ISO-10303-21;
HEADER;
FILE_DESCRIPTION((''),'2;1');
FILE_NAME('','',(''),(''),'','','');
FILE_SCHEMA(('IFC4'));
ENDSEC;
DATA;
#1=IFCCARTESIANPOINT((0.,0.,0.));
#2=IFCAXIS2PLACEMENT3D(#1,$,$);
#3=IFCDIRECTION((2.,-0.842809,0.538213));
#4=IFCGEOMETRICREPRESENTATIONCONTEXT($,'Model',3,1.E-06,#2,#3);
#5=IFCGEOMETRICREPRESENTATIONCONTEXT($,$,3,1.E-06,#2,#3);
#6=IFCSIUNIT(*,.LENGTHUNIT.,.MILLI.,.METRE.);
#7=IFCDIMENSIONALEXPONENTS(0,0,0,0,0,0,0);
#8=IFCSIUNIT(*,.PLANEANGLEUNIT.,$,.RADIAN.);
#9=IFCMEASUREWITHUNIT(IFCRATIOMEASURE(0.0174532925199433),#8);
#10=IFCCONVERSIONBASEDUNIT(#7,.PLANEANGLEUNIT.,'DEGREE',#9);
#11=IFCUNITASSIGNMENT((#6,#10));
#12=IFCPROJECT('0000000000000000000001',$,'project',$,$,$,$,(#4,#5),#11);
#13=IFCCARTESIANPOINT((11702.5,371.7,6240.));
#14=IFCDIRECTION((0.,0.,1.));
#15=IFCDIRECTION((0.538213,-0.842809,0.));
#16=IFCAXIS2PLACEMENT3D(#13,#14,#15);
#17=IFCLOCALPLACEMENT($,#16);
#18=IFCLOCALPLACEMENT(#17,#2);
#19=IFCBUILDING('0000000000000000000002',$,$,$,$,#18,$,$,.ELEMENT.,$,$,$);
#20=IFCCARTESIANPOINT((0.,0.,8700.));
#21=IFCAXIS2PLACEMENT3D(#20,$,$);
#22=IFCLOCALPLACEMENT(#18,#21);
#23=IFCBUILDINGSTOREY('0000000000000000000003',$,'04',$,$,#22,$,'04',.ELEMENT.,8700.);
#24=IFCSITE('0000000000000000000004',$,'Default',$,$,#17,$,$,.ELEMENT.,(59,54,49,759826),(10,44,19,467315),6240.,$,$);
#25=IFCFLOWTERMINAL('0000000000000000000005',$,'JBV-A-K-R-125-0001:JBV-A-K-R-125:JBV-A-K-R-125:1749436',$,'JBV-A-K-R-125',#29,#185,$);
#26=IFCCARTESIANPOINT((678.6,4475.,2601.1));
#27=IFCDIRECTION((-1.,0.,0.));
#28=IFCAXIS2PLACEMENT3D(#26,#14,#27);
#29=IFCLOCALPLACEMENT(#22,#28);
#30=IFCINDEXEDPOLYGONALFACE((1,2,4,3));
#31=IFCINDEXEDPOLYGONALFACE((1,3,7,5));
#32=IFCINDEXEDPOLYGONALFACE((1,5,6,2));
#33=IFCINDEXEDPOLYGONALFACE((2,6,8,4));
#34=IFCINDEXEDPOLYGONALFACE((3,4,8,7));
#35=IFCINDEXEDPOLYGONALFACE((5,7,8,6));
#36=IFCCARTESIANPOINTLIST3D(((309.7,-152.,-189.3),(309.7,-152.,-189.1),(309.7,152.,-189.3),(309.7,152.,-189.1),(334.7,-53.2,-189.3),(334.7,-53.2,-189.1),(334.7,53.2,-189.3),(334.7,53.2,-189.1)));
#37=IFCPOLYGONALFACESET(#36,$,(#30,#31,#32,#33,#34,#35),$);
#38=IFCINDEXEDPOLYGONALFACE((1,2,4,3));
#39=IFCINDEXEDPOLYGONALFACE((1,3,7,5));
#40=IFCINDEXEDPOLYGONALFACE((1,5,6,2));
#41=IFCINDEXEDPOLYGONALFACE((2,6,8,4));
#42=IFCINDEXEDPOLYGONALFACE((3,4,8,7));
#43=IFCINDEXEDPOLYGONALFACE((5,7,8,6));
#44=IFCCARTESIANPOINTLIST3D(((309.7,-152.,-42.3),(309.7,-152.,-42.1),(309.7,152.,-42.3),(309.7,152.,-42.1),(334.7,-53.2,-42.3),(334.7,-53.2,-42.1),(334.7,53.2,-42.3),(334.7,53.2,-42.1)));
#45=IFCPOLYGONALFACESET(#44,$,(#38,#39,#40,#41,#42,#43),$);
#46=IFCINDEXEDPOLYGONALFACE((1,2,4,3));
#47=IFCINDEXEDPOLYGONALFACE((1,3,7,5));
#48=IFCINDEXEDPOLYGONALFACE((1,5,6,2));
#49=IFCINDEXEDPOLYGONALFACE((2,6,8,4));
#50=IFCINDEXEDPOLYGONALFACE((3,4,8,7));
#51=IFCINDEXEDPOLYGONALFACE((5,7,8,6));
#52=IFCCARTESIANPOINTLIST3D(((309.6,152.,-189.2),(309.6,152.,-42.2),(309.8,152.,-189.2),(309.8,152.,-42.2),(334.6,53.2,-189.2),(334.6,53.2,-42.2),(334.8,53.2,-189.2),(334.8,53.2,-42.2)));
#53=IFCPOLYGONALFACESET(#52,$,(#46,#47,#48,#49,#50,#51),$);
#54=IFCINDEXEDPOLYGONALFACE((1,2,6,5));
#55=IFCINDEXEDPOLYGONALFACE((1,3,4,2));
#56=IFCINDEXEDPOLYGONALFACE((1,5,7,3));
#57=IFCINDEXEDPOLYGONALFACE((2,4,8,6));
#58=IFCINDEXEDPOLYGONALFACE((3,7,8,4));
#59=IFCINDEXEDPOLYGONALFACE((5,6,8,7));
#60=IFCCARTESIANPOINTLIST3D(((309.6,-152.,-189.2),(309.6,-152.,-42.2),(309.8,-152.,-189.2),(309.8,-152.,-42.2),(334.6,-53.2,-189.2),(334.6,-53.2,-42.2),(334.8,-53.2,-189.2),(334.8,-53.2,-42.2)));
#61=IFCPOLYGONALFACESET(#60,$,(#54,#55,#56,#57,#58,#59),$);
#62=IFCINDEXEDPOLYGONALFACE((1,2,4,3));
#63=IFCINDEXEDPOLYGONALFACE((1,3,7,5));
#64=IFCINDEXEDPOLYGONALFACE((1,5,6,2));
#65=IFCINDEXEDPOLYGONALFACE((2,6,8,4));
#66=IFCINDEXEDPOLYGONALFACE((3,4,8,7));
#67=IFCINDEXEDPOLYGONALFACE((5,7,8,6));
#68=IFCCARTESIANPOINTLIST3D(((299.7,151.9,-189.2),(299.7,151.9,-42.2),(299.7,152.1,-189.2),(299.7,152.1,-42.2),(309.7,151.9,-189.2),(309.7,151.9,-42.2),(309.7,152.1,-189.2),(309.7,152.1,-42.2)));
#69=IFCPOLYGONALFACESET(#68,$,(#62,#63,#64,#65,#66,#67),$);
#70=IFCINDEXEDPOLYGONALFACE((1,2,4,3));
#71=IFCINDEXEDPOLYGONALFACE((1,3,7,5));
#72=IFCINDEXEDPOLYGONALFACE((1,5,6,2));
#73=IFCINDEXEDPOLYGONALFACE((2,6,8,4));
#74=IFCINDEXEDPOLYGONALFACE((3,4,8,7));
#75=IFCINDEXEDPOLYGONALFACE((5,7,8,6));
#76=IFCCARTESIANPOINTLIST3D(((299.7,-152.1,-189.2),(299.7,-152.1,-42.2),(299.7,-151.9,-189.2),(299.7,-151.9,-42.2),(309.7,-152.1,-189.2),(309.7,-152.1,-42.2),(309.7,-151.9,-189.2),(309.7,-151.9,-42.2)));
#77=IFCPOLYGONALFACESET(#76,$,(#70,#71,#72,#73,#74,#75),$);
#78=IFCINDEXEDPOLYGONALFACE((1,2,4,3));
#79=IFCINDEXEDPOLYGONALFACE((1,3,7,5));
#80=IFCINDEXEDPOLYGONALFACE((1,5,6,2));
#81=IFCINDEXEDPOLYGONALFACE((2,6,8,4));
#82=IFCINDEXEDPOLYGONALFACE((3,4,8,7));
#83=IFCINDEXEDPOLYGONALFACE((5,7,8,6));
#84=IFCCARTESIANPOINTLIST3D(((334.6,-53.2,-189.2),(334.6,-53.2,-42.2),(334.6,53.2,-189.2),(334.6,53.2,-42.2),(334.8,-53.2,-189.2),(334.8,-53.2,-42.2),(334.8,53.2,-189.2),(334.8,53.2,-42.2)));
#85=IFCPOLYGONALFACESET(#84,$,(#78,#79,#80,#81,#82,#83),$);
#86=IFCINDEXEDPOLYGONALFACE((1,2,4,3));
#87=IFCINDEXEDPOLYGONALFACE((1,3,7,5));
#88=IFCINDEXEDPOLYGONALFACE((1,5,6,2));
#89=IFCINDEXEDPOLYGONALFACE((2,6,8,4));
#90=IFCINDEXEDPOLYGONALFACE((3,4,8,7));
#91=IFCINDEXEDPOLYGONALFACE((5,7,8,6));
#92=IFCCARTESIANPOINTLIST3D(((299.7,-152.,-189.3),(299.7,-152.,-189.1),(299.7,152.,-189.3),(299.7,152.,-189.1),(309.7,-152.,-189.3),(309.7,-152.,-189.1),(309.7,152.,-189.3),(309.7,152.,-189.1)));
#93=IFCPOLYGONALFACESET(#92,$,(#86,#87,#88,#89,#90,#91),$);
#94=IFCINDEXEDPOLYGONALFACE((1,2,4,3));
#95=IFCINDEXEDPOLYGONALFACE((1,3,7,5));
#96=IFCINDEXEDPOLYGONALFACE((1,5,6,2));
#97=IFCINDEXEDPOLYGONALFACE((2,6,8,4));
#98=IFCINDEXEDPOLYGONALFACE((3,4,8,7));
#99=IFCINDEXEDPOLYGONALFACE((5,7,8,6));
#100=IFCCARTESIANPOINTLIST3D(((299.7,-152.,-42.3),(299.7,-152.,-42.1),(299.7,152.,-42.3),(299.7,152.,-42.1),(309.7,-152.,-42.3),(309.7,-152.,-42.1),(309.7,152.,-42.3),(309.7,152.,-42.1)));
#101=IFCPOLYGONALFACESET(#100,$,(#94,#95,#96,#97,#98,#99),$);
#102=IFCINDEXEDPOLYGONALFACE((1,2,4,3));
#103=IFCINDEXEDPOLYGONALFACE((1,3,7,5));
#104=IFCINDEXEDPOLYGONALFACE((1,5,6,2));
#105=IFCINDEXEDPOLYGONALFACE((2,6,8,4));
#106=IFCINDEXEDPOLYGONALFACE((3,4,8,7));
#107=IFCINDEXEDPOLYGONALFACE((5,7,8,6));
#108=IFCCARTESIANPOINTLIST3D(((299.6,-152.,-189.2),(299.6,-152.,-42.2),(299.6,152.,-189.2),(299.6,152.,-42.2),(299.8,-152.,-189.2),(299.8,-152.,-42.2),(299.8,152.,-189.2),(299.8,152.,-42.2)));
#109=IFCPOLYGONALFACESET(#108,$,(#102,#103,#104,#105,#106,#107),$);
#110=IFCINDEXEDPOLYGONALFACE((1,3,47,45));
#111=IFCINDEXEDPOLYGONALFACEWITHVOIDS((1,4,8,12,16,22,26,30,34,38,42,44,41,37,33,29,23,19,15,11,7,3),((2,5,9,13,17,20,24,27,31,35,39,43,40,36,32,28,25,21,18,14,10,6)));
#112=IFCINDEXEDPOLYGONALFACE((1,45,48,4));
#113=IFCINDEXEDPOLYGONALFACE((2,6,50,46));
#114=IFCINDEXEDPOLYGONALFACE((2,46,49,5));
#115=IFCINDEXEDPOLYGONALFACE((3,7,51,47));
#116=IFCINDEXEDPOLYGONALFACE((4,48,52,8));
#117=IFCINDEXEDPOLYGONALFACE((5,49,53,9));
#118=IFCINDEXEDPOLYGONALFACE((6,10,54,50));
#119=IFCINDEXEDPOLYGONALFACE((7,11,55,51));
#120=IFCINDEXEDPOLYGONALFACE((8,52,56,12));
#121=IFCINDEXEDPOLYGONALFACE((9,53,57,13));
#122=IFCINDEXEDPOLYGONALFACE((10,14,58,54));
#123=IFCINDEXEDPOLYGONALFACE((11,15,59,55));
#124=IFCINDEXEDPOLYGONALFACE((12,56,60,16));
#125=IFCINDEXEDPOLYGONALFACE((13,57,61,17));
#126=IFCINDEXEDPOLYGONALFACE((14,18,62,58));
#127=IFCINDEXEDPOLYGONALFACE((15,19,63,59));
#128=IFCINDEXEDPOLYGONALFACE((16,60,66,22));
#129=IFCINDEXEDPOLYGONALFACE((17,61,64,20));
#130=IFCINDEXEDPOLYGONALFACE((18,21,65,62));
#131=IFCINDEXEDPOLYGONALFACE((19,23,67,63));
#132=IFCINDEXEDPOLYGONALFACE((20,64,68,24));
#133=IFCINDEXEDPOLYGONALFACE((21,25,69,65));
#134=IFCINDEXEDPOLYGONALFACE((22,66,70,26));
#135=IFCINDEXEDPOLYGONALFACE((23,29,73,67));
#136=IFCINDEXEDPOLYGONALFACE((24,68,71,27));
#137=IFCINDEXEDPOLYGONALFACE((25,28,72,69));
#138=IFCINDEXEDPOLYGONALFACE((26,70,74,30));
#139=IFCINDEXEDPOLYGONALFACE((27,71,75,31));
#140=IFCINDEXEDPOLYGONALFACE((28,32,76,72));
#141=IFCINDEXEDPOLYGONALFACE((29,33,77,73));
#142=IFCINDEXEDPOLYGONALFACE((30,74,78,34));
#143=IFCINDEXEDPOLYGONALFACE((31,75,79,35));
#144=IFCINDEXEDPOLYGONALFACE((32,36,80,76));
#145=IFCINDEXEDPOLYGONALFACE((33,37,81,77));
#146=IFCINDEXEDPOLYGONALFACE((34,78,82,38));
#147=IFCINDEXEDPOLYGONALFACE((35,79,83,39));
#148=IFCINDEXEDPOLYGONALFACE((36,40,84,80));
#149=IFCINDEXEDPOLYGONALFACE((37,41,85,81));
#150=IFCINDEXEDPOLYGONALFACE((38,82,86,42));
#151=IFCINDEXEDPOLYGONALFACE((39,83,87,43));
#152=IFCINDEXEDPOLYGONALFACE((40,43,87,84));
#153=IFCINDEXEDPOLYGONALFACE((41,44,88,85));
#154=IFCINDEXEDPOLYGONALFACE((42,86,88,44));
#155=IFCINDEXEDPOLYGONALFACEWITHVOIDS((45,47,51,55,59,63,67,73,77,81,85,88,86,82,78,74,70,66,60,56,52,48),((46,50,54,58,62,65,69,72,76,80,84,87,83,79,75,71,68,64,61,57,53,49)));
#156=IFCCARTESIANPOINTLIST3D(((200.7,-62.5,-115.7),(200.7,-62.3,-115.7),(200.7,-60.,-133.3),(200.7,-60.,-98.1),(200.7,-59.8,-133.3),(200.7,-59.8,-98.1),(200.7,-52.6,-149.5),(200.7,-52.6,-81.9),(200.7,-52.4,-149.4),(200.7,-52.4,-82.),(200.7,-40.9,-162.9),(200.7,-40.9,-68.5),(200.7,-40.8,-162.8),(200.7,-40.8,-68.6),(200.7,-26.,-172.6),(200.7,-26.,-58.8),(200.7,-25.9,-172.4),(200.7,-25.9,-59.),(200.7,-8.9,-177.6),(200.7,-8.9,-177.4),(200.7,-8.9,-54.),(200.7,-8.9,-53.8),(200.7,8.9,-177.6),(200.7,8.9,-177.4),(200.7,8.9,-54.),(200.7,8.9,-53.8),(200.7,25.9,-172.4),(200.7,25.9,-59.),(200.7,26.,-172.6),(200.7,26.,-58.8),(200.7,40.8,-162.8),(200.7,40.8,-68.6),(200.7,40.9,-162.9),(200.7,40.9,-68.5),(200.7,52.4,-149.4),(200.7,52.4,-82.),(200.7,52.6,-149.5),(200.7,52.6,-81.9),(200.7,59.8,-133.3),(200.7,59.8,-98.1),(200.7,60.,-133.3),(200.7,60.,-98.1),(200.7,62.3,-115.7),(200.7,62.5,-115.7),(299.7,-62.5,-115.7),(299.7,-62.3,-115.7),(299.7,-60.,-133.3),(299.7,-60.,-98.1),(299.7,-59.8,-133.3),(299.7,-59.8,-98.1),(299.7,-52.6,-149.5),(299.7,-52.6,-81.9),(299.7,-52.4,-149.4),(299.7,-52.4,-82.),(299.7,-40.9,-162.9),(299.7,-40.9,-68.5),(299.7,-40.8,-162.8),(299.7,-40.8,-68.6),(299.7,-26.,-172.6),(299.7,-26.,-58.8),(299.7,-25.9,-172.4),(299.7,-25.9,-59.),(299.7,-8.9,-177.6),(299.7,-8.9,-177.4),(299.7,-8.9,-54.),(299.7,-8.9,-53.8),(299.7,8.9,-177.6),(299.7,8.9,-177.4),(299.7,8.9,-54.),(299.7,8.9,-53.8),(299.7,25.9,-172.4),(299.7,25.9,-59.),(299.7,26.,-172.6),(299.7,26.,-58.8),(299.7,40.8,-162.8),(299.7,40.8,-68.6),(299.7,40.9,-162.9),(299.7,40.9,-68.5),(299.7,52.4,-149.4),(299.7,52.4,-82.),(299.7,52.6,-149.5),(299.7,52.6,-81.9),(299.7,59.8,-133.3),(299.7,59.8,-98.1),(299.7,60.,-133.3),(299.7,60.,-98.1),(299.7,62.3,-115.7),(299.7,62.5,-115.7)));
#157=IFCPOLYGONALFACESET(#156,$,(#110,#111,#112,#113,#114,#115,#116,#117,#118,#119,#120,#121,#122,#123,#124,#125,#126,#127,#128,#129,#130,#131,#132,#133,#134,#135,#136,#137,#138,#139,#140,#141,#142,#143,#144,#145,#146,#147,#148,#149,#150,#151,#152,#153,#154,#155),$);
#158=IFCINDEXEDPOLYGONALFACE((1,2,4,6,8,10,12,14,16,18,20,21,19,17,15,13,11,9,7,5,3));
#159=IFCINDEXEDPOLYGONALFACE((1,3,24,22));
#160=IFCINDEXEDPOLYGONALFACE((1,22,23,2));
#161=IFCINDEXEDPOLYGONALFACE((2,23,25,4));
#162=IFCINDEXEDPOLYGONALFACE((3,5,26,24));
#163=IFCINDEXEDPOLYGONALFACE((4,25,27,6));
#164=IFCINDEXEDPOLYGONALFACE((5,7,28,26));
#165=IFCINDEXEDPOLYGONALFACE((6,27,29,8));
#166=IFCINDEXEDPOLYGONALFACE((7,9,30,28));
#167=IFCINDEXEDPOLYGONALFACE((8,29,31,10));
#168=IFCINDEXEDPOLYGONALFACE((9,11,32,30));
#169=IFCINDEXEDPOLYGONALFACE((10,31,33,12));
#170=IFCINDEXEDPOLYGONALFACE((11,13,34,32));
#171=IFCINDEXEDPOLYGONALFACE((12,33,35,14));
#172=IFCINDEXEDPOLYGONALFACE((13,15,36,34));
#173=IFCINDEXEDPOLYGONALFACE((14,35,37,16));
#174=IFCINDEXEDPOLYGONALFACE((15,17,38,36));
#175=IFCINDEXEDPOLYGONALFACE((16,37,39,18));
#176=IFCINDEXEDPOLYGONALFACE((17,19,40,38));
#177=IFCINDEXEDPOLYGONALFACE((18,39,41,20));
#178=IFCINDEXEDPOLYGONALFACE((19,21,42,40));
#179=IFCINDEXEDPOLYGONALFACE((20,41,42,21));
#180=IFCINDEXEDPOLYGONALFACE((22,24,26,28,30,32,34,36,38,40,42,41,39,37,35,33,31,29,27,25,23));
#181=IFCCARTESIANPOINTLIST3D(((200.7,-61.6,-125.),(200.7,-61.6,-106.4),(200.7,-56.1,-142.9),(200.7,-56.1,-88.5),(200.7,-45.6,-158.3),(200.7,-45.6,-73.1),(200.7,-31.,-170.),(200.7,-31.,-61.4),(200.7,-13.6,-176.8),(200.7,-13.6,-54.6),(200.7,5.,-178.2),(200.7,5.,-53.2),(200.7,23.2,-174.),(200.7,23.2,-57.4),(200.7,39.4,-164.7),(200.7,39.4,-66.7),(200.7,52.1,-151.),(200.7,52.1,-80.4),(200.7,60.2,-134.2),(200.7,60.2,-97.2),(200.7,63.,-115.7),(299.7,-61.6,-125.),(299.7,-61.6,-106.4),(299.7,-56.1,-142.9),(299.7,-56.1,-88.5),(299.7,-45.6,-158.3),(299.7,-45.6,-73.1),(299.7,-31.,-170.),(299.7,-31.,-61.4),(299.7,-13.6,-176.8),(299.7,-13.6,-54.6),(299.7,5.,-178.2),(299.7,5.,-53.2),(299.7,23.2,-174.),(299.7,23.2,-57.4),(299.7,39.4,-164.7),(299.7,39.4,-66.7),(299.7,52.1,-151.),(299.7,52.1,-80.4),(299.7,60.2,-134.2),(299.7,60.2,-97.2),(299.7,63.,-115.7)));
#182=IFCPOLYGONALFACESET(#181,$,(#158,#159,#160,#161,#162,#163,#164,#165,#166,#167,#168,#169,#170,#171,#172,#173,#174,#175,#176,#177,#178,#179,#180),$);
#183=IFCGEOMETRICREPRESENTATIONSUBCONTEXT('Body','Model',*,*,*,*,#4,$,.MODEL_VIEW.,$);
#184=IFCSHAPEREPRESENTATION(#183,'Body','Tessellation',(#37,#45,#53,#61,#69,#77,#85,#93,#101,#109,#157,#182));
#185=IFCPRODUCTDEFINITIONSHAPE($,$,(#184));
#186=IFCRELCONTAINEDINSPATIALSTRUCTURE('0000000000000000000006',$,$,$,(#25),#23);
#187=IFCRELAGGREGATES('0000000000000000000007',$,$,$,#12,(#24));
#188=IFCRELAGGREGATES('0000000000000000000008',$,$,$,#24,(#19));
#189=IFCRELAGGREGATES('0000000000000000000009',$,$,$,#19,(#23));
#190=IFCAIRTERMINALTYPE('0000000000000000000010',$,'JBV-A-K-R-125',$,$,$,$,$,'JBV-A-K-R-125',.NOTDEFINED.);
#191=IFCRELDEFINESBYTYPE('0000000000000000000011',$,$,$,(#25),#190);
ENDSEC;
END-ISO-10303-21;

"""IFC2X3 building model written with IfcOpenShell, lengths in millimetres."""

from ifc_helpers import new_model, entity, si_unit, converted_unit, direction, frame, frame_2d, origin, origin_2d_with_axis, place, context, subcontext, project, spatial, polyline, circle_curve, parameter, trimmed, segment, composite_curve, rectangle, circle, outline, extrude, source, transform, mapped, type_object, type_shapes, element, save


model = new_model("IFC2X3")

# Units and contexts
model_context = context("Model", 3, precision=1e-06, world=origin(), true_north=direction((2.0, -0.842809, 0.538213)))
context_of_model = context(None, 3, precision=1e-06, world=origin(), true_north=direction((2.0, -0.842809, 0.538213)))
body_context = subcontext(model_context, "Body", "Model", "MODEL_VIEW")
ifc_project = project(units=[si_unit("LENGTHUNIT", "METRE", prefix="MILLI"), converted_unit("PLANEANGLEUNIT", "DEGREE", entity("IfcRatioMeasure", 0.0174532925199433), si_unit("PLANEANGLEUNIT", "RADIAN"), dimensions=[0, 0, 0, 0, 0, 0, 0])], contexts=[model_context, context_of_model])

# Site, building, storey
site_placement = place(None, frame((11702.5, 371.7, 6240.0), z_axis=(0.0, 0.0, 1.0), x_axis=(0.538213, -0.842809, 0.0)))
site = spatial("IfcSite", under=ifc_project, at=site_placement, Name="Default", CompositionType="ELEMENT", RefLatitude=(59, 54, 49, 759826), RefLongitude=(10, 44, 19, 467315), RefElevation=6240.0)
building_placement = place(site_placement, origin())
building = spatial("IfcBuilding", under=site, at=building_placement, CompositionType="ELEMENT")
storey_placement = place(building_placement, frame((0.0, 0.0, 8700.0)))
storey = spatial("IfcBuildingStorey", under=building, at=storey_placement, Name="04", LongName="04", CompositionType="ELEMENT", Elevation=8700.0)

# Flow terminal
air_terminal_type_1 = type_object("IfcAirTerminalType", Name="JBV-A-K-R-125", ElementType="JBV-A-K-R-125", PredefinedType="NOTDEFINED")
shared_shape_1 = source(origin(), body_context, "Body", "SweptSolid", [
    extrude(outline(polyline([(-152.0, -12.5), (152.0, -12.5), (53.2, 12.5), (-53.2, 12.5), (-152.0, -12.5)])), frame((322.2, 0.0, -189.3), z_axis=(0.0, 0.0, 1.0), x_axis=(0.0, -1.0, 0.0)), (0.0, 0.0, 1.0), 0.2),
    extrude(outline(polyline([(-152.0, -12.5), (152.0, -12.5), (53.2, 12.5), (-53.2, 12.5), (-152.0, -12.5)])), frame((322.2, 0.0, -42.3), z_axis=(0.0, 0.0, 1.0), x_axis=(0.0, -1.0, 0.0)), (0.0, 0.0, 1.0), 0.2),
    extrude(rectangle(XDim=0.2, YDim=101.9, at=frame_2d((0.0, 0.0), x_axis=(1.0, 0.0))), frame((322.2, 102.6, -189.2), z_axis=(0.0, 0.0, 1.0), x_axis=(0.969446, 0.245305, 0.0)), (0.0, 0.0, 1.0), 147.0),
    extrude(rectangle(XDim=0.2, YDim=101.9, at=frame_2d((0.0, 0.0), x_axis=(1.0, 0.0))), frame((322.2, -102.6, -189.2), z_axis=(0.0, 0.0, 1.0), x_axis=(-0.969446, 0.245305, 0.0)), (0.0, 0.0, 1.0), 147.0),
    extrude(rectangle(XDim=0.2, YDim=10.0, at=frame_2d((0.0, 0.0), x_axis=(1.0, 0.0))), frame((304.7, 152.0, -189.2), z_axis=(0.0, 0.0, 1.0), x_axis=(0.0, 1.0, 0.0)), (0.0, 0.0, 1.0), 147.0),
    extrude(rectangle(XDim=0.2, YDim=10.0, at=frame_2d((0.0, 0.0), x_axis=(1.0, 0.0))), frame((304.7, -152.0, -189.2), z_axis=(0.0, 0.0, 1.0), x_axis=(0.0, 1.0, 0.0)), (0.0, 0.0, 1.0), 147.0),
    extrude(rectangle(XDim=0.2, YDim=106.4, at=frame_2d((0.0, 0.0), x_axis=(1.0, 0.0))), frame((334.7, 0.0, -189.2)), (0.0, 0.0, 1.0), 147.0),
    extrude(rectangle(XDim=304.0, YDim=10.0, at=frame_2d((0.0, 0.0), x_axis=(1.0, 0.0))), frame((304.7, 0.0, -189.3), z_axis=(0.0, 0.0, 1.0), x_axis=(0.0, -1.0, 0.0)), (0.0, 0.0, 1.0), 0.2),
    extrude(rectangle(XDim=304.0, YDim=10.0, at=frame_2d((0.0, 0.0), x_axis=(1.0, 0.0))), frame((304.7, 0.0, -42.3), z_axis=(0.0, 0.0, 1.0), x_axis=(0.0, -1.0, 0.0)), (0.0, 0.0, 1.0), 0.2),
    extrude(rectangle(XDim=0.2, YDim=304.0, at=frame_2d((0.0, 0.0), x_axis=(1.0, 0.0))), frame((299.7, 0.0, -189.2)), (0.0, 0.0, 1.0), 147.0),
    extrude(outline(composite_curve([segment(trimmed(circle_curve(origin_2d_with_axis(), 62.5), [parameter(0.0)], [parameter(180.0)], True, "PARAMETER"), True, "CONTINUOUS"), segment(trimmed(circle_curve(origin_2d_with_axis(), 62.5), [parameter(180.0)], [parameter(360.0)], True, "PARAMETER"), True, "CONTINUOUS")], self_intersect=False), holes=[composite_curve([segment(trimmed(circle_curve(origin_2d_with_axis(), 62.3), [parameter(180.0)], [parameter(360.0)], True, "PARAMETER"), False, "CONTINUOUS"), segment(trimmed(circle_curve(origin_2d_with_axis(), 62.3), [parameter(0.0)], [parameter(180.0)], True, "PARAMETER"), False, "CONTINUOUS")], self_intersect=False)]), frame((200.7, 0.0, -115.7), z_axis=(1.0, 0.0, 0.0), x_axis=(0.0, 1.0, 0.0)), (0.0, 0.0, 1.0), 99.0),
    extrude(circle(Radius=62.6, at=frame_2d((0.0, 0.0), x_axis=(1.0, 0.0))), frame((200.7, 0.3, -115.7), z_axis=(1.0, 0.0, 0.0), x_axis=(0.0, 1.0, 0.0)), (0.0, 0.0, 1.0), 99.0),
])
type_shapes(air_terminal_type_1, [shared_shape_1])
flow_terminal_1_placement = place(storey_placement, frame((678.6, 4475.0, 2601.1), z_axis=(0.0, 0.0, 1.0), x_axis=(-1.0, 0.0, 0.0)))
element("IfcFlowTerminal", 1, at=flow_terminal_1_placement, inside=storey, type_object=air_terminal_type_1, Name="JBV-A-K-R-125-0001:JBV-A-K-R-125:JBV-A-K-R-125:1749436", ObjectType="JBV-A-K-R-125", context=body_context, shape_type="MappedRepresentation", body=[
    mapped(shared_shape_1, transform((0.0, 0.0, 0.0), scale=1.0)),
])

save(model, "model.ifc")
